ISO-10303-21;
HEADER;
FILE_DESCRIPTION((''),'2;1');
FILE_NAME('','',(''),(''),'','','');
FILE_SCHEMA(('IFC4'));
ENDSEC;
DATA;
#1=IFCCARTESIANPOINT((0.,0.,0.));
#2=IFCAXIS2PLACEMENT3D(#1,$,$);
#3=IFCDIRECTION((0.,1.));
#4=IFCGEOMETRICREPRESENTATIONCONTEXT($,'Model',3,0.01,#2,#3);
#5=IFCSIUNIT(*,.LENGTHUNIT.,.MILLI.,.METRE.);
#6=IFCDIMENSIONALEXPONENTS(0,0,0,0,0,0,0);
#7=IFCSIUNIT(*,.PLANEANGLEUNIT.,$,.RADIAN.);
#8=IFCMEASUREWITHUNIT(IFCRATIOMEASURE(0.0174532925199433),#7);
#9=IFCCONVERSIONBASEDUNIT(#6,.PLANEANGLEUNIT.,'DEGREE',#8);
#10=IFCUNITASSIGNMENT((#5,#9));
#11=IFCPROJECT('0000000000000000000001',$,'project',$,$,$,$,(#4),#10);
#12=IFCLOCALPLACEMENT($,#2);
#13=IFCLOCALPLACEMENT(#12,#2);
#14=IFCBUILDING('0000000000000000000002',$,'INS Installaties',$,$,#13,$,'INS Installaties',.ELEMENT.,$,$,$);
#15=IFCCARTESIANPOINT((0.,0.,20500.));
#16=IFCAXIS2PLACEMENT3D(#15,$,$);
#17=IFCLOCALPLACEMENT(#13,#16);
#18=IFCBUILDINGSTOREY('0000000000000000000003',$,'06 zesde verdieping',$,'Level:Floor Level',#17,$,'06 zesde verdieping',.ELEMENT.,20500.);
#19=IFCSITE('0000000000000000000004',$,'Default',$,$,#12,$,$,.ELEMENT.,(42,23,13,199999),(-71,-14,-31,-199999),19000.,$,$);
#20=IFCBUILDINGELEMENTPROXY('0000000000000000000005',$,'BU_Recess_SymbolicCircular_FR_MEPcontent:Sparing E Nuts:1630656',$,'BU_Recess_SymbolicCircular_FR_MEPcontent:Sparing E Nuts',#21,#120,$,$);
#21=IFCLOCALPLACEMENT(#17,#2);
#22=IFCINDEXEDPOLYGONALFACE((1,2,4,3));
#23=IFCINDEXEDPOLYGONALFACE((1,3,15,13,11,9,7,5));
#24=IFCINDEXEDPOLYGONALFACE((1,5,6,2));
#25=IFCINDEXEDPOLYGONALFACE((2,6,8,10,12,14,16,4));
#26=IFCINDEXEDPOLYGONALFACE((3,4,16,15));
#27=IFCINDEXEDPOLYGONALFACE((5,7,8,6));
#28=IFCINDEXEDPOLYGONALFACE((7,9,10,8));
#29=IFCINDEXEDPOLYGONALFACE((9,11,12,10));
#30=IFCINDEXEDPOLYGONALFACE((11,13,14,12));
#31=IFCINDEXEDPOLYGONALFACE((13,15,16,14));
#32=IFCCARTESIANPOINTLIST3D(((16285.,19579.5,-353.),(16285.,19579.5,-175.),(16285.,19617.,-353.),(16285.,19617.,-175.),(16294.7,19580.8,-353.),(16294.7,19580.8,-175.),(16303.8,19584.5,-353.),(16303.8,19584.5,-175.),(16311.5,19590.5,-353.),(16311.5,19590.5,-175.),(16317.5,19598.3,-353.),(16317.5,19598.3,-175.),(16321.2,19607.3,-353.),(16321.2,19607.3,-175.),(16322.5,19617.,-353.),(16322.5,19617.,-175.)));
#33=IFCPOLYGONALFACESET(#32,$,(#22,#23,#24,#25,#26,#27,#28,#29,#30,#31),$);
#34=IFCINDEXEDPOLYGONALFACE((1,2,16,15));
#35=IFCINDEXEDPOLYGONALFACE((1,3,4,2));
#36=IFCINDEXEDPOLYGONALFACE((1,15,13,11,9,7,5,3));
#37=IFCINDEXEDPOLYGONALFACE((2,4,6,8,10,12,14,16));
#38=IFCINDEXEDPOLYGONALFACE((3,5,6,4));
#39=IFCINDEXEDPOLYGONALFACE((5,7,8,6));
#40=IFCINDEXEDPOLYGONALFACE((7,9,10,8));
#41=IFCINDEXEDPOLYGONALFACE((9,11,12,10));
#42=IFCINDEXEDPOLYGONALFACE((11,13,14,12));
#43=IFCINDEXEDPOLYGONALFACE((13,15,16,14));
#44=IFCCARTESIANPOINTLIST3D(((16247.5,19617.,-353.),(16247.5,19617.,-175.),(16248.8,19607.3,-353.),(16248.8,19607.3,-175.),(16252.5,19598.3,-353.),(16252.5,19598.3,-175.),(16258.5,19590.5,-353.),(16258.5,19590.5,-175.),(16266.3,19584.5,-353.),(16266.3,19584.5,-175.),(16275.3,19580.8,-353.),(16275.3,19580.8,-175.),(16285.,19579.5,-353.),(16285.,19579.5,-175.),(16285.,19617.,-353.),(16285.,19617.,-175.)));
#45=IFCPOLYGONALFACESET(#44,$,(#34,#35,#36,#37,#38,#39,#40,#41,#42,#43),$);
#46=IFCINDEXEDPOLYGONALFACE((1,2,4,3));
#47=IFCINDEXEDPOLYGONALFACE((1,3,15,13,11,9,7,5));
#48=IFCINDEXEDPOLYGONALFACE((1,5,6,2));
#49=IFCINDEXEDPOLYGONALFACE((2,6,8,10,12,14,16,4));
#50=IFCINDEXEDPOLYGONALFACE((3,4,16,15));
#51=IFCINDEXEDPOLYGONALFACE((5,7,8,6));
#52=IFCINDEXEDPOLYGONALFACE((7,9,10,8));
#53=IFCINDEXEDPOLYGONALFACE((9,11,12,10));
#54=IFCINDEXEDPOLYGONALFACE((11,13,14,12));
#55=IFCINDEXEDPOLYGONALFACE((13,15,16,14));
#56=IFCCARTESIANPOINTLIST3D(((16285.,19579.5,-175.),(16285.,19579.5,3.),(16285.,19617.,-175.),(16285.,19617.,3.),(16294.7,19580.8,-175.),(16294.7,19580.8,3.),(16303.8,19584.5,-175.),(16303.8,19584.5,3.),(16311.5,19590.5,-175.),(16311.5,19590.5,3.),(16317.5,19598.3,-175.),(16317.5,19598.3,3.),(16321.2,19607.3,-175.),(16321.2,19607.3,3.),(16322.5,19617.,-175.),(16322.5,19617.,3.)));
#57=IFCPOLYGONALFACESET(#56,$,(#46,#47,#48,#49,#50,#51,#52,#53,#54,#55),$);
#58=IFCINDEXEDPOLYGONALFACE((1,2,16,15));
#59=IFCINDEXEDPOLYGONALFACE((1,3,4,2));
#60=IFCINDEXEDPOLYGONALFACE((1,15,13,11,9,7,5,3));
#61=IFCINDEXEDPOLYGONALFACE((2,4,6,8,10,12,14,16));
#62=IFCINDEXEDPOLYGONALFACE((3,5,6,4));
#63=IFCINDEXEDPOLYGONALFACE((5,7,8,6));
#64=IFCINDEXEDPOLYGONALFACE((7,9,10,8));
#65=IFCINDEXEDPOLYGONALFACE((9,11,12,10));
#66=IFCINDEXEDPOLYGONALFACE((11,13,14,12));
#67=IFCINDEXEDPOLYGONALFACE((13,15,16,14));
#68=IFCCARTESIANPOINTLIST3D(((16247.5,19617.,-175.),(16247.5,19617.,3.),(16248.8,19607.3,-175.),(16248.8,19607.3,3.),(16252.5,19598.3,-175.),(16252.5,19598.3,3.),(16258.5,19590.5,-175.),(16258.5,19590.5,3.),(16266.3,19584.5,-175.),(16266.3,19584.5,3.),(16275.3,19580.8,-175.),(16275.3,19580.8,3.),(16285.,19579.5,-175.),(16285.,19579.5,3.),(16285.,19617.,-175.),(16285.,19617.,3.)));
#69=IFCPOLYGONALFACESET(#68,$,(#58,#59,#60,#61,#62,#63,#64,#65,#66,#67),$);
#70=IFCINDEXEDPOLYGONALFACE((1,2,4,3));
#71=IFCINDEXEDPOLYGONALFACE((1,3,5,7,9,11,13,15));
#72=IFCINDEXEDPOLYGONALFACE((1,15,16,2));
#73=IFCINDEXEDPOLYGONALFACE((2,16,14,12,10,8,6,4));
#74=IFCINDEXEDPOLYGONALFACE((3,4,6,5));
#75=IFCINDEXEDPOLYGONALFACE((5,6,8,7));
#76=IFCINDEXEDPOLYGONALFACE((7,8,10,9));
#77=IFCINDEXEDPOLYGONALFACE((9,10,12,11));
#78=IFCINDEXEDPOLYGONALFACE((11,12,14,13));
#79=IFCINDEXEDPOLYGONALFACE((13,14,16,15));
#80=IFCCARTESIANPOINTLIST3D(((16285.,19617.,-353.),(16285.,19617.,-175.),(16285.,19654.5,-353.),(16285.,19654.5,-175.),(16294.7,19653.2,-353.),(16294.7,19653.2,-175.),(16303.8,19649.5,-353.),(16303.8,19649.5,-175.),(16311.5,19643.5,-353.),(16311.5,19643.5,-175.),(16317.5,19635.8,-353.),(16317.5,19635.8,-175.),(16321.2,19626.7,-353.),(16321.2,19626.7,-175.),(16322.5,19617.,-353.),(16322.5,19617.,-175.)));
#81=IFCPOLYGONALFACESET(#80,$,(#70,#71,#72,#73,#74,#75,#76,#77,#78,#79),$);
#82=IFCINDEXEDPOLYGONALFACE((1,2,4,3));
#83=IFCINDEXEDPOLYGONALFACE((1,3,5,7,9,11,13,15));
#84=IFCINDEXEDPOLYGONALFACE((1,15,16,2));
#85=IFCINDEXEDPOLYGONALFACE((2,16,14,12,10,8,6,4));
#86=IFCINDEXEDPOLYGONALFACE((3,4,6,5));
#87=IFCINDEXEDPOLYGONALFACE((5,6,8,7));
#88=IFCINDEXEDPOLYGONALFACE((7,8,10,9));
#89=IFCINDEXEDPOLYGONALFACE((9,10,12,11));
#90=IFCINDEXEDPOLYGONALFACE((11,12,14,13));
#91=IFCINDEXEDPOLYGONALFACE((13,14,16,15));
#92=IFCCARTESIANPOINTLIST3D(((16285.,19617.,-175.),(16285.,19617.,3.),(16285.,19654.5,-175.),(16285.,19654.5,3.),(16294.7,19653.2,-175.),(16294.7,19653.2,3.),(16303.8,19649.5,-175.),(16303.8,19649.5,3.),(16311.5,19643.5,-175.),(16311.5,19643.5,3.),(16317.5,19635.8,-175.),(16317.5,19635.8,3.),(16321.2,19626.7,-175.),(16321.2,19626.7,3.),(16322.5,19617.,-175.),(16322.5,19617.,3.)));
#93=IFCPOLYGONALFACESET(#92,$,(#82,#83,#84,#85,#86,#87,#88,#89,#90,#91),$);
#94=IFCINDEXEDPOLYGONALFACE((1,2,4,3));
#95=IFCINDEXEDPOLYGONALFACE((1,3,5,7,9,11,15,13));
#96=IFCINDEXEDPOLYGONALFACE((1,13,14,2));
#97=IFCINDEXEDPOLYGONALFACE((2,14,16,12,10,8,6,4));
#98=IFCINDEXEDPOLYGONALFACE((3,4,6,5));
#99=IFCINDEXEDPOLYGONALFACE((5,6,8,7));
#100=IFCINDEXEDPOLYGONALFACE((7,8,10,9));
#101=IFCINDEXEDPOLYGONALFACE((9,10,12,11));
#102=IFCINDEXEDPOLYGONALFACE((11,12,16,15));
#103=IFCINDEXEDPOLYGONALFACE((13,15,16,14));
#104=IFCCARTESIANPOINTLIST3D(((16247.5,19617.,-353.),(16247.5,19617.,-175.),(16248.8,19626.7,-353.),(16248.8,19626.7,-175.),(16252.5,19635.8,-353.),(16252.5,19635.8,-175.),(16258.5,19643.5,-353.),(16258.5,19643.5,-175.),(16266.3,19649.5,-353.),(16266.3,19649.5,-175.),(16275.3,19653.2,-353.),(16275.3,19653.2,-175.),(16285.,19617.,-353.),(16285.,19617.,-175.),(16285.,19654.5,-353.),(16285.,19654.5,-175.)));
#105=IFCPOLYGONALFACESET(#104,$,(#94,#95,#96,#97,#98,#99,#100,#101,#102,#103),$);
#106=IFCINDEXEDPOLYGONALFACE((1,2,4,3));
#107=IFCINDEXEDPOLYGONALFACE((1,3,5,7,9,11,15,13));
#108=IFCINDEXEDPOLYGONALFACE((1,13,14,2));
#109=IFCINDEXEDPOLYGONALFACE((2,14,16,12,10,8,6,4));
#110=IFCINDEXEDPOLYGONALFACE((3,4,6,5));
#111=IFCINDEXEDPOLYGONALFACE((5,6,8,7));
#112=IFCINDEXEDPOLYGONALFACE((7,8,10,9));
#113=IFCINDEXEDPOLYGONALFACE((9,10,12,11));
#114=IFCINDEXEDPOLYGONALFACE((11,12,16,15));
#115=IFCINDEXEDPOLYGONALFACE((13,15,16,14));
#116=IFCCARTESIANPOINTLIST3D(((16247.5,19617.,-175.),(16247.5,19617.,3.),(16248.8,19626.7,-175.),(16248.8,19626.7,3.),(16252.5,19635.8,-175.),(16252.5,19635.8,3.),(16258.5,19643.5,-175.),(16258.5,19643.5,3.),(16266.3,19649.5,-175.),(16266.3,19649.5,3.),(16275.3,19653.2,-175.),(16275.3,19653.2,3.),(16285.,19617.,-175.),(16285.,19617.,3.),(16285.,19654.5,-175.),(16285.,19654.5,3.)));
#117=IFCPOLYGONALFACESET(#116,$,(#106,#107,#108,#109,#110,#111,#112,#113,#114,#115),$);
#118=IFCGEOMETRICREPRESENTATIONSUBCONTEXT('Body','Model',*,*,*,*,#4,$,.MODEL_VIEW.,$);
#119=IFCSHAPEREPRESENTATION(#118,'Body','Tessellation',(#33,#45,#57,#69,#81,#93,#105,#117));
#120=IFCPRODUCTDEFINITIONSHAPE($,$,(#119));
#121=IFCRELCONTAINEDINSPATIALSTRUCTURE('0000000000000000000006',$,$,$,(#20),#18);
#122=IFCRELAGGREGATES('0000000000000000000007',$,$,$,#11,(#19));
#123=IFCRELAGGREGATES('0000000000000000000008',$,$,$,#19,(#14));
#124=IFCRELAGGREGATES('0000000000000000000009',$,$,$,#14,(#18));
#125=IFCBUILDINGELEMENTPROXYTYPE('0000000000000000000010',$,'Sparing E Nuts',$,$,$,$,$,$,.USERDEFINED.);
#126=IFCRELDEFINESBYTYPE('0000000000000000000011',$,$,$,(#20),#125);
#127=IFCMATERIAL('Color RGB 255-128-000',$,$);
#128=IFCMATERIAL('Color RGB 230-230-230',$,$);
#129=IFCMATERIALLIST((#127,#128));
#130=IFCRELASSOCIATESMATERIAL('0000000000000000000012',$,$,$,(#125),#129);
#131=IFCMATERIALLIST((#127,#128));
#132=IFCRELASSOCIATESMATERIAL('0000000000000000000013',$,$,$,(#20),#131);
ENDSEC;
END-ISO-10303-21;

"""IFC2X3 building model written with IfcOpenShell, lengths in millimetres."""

from ifc_helpers import new_model, entity, si_unit, converted_unit, direction, frame, frame_2d, origin, place, context, subcontext, project, spatial, polyline, circle_curve, parameter, trimmed, segment, composite_curve, outline, extrude, source, transform, mapped, material, material_list, type_object, type_shapes, element, save


model = new_model("IFC2X3")

# Units and contexts
model_context = context("Model", 3, precision=0.01, world=origin(), true_north=direction((0.0, 1.0)))
body_context = subcontext(model_context, "Body", "Model", "MODEL_VIEW")
ifc_project = project(units=[si_unit("LENGTHUNIT", "METRE", prefix="MILLI"), converted_unit("PLANEANGLEUNIT", "DEGREE", entity("IfcRatioMeasure", 0.0174532925199433), si_unit("PLANEANGLEUNIT", "RADIAN"), dimensions=[0, 0, 0, 0, 0, 0, 0])], contexts=[model_context])

# Site, building, storey
site_placement = place(None, origin())
site = spatial("IfcSite", under=ifc_project, at=site_placement, Name="Default", CompositionType="ELEMENT", RefLatitude=(42, 23, 13, 199999), RefLongitude=(-71, -14, -31, -199999), RefElevation=19000.0)
building_placement = place(site_placement, origin())
building = spatial("IfcBuilding", under=site, at=building_placement, Name="INS Installaties", LongName="INS Installaties", CompositionType="ELEMENT")
storey_placement = place(building_placement, frame((0.0, 0.0, 20500.0)))
storey = spatial("IfcBuildingStorey", under=building, at=storey_placement, Name="06 zesde verdieping", ObjectType="Level:Floor Level", LongName="06 zesde verdieping", CompositionType="ELEMENT", Elevation=20500.0)

# Building element proxy
ifc_material_1 = material(Name="Color RGB 255-128-000")
ifc_material_2 = material(Name="Color RGB 230-230-230")
ifc_material_list_1 = material_list([ifc_material_1, ifc_material_2])
building_element_proxy_type_1 = type_object("IfcBuildingElementProxyType", Name="Sparing E Nuts", PredefinedType="USERDEFINED", material=ifc_material_list_1)
shared_shape_1 = source(origin(), body_context, "Body", "SweptSolid", [
    extrude(outline(composite_curve([segment(polyline([(-25.0, -12.5), (12.5, -12.5)]), True, "CONTINUOUS"), segment(polyline([(12.5, -12.5), (12.5, 25.0)]), True, "CONTINUOUS"), segment(trimmed(circle_curve(frame_2d((12.5, -12.5), x_axis=(1.0, 0.0)), 37.5), [parameter(90.0)], [parameter(180.0)], True, "PARAMETER"), True, "CONTINUOUS")], self_intersect=False)), frame((12.5, -12.5, -353.0), z_axis=(0.0, 0.0, 1.0), x_axis=(-1.0, 0.0, 0.0)), (0.0, 0.0, 1.0), 178.0),
    extrude(outline(composite_curve([segment(trimmed(circle_curve(frame_2d((12.5, 12.5), x_axis=(1.0, 0.0)), 37.5), [parameter(180.0)], [parameter(270.0)], True, "PARAMETER"), True, "CONTINUOUS"), segment(polyline([(12.5, -25.0), (12.5, 12.5)]), True, "CONTINUOUS"), segment(polyline([(12.5, 12.5), (-25.0, 12.5)]), True, "CONTINUOUS")], self_intersect=False)), frame((-12.5, -12.5, -353.0)), (0.0, 0.0, 1.0), 178.0),
    extrude(outline(composite_curve([segment(polyline([(-25.0, -12.5), (12.5, -12.5)]), True, "CONTINUOUS"), segment(polyline([(12.5, -12.5), (12.5, 25.0)]), True, "CONTINUOUS"), segment(trimmed(circle_curve(frame_2d((12.5, -12.5), x_axis=(1.0, 0.0)), 37.5), [parameter(90.0)], [parameter(180.0)], True, "PARAMETER"), True, "CONTINUOUS")], self_intersect=False)), frame((12.5, -12.5, -175.0), z_axis=(0.0, 0.0, 1.0), x_axis=(-1.0, 0.0, 0.0)), (0.0, 0.0, 1.0), 178.0),
    extrude(outline(composite_curve([segment(trimmed(circle_curve(frame_2d((12.5, 12.5), x_axis=(1.0, 0.0)), 37.5), [parameter(180.0)], [parameter(270.0)], True, "PARAMETER"), True, "CONTINUOUS"), segment(polyline([(12.5, -25.0), (12.5, 12.5)]), True, "CONTINUOUS"), segment(polyline([(12.5, 12.5), (-25.0, 12.5)]), True, "CONTINUOUS")], self_intersect=False)), frame((-12.5, -12.5, -175.0)), (0.0, 0.0, 1.0), 178.0),
    extrude(outline(composite_curve([segment(trimmed(circle_curve(frame_2d((12.5, 12.5), x_axis=(1.0, 0.0)), 37.5), [parameter(180.0)], [parameter(270.0)], True, "PARAMETER"), True, "CONTINUOUS"), segment(polyline([(12.5, -25.0), (12.5, 12.5)]), True, "CONTINUOUS"), segment(polyline([(12.5, 12.5), (-25.0, 12.5)]), True, "CONTINUOUS")], self_intersect=False)), frame((12.5, 12.5, -353.0), z_axis=(0.0, 0.0, 1.0), x_axis=(-1.0, 0.0, 0.0)), (0.0, 0.0, 1.0), 178.0),
    extrude(outline(composite_curve([segment(trimmed(circle_curve(frame_2d((12.5, 12.5), x_axis=(1.0, 0.0)), 37.5), [parameter(180.0)], [parameter(270.0)], True, "PARAMETER"), True, "CONTINUOUS"), segment(polyline([(12.5, -25.0), (12.5, 12.5)]), True, "CONTINUOUS"), segment(polyline([(12.5, 12.5), (-25.0, 12.5)]), True, "CONTINUOUS")], self_intersect=False)), frame((12.5, 12.5, -175.0), z_axis=(0.0, 0.0, 1.0), x_axis=(-1.0, 0.0, 0.0)), (0.0, 0.0, 1.0), 178.0),
    extrude(outline(composite_curve([segment(polyline([(-25.0, -12.5), (12.5, -12.5)]), True, "CONTINUOUS"), segment(polyline([(12.5, -12.5), (12.5, 25.0)]), True, "CONTINUOUS"), segment(trimmed(circle_curve(frame_2d((12.5, -12.5), x_axis=(1.0, 0.0)), 37.5), [parameter(90.0)], [parameter(180.0)], True, "PARAMETER"), True, "CONTINUOUS")], self_intersect=False)), frame((-12.5, 12.5, -353.0)), (0.0, 0.0, 1.0), 178.0),
    extrude(outline(composite_curve([segment(polyline([(-25.0, -12.5), (12.5, -12.5)]), True, "CONTINUOUS"), segment(polyline([(12.5, -12.5), (12.5, 25.0)]), True, "CONTINUOUS"), segment(trimmed(circle_curve(frame_2d((12.5, -12.5), x_axis=(1.0, 0.0)), 37.5), [parameter(90.0)], [parameter(180.0)], True, "PARAMETER"), True, "CONTINUOUS")], self_intersect=False)), frame((-12.5, 12.5, -175.0)), (0.0, 0.0, 1.0), 178.0),
])
type_shapes(building_element_proxy_type_1, [shared_shape_1])
ifc_material_list_2 = material_list([ifc_material_1, ifc_material_2])
proxy_1_placement = place(storey_placement, frame((16285.0, 19617.0, 0.0)))
element("IfcBuildingElementProxy", 1, at=proxy_1_placement, inside=storey, type_object=building_element_proxy_type_1, material=ifc_material_list_2, Name="BU_Recess_SymbolicCircular_FR_MEPcontent:Sparing E Nuts:1630656", ObjectType="BU_Recess_SymbolicCircular_FR_MEPcontent:Sparing E Nuts", context=body_context, shape_type="MappedRepresentation", body=[
    mapped(shared_shape_1, transform((0.0, 0.0, 0.0), scale=1.0)),
])

save(model, "model.ifc")
